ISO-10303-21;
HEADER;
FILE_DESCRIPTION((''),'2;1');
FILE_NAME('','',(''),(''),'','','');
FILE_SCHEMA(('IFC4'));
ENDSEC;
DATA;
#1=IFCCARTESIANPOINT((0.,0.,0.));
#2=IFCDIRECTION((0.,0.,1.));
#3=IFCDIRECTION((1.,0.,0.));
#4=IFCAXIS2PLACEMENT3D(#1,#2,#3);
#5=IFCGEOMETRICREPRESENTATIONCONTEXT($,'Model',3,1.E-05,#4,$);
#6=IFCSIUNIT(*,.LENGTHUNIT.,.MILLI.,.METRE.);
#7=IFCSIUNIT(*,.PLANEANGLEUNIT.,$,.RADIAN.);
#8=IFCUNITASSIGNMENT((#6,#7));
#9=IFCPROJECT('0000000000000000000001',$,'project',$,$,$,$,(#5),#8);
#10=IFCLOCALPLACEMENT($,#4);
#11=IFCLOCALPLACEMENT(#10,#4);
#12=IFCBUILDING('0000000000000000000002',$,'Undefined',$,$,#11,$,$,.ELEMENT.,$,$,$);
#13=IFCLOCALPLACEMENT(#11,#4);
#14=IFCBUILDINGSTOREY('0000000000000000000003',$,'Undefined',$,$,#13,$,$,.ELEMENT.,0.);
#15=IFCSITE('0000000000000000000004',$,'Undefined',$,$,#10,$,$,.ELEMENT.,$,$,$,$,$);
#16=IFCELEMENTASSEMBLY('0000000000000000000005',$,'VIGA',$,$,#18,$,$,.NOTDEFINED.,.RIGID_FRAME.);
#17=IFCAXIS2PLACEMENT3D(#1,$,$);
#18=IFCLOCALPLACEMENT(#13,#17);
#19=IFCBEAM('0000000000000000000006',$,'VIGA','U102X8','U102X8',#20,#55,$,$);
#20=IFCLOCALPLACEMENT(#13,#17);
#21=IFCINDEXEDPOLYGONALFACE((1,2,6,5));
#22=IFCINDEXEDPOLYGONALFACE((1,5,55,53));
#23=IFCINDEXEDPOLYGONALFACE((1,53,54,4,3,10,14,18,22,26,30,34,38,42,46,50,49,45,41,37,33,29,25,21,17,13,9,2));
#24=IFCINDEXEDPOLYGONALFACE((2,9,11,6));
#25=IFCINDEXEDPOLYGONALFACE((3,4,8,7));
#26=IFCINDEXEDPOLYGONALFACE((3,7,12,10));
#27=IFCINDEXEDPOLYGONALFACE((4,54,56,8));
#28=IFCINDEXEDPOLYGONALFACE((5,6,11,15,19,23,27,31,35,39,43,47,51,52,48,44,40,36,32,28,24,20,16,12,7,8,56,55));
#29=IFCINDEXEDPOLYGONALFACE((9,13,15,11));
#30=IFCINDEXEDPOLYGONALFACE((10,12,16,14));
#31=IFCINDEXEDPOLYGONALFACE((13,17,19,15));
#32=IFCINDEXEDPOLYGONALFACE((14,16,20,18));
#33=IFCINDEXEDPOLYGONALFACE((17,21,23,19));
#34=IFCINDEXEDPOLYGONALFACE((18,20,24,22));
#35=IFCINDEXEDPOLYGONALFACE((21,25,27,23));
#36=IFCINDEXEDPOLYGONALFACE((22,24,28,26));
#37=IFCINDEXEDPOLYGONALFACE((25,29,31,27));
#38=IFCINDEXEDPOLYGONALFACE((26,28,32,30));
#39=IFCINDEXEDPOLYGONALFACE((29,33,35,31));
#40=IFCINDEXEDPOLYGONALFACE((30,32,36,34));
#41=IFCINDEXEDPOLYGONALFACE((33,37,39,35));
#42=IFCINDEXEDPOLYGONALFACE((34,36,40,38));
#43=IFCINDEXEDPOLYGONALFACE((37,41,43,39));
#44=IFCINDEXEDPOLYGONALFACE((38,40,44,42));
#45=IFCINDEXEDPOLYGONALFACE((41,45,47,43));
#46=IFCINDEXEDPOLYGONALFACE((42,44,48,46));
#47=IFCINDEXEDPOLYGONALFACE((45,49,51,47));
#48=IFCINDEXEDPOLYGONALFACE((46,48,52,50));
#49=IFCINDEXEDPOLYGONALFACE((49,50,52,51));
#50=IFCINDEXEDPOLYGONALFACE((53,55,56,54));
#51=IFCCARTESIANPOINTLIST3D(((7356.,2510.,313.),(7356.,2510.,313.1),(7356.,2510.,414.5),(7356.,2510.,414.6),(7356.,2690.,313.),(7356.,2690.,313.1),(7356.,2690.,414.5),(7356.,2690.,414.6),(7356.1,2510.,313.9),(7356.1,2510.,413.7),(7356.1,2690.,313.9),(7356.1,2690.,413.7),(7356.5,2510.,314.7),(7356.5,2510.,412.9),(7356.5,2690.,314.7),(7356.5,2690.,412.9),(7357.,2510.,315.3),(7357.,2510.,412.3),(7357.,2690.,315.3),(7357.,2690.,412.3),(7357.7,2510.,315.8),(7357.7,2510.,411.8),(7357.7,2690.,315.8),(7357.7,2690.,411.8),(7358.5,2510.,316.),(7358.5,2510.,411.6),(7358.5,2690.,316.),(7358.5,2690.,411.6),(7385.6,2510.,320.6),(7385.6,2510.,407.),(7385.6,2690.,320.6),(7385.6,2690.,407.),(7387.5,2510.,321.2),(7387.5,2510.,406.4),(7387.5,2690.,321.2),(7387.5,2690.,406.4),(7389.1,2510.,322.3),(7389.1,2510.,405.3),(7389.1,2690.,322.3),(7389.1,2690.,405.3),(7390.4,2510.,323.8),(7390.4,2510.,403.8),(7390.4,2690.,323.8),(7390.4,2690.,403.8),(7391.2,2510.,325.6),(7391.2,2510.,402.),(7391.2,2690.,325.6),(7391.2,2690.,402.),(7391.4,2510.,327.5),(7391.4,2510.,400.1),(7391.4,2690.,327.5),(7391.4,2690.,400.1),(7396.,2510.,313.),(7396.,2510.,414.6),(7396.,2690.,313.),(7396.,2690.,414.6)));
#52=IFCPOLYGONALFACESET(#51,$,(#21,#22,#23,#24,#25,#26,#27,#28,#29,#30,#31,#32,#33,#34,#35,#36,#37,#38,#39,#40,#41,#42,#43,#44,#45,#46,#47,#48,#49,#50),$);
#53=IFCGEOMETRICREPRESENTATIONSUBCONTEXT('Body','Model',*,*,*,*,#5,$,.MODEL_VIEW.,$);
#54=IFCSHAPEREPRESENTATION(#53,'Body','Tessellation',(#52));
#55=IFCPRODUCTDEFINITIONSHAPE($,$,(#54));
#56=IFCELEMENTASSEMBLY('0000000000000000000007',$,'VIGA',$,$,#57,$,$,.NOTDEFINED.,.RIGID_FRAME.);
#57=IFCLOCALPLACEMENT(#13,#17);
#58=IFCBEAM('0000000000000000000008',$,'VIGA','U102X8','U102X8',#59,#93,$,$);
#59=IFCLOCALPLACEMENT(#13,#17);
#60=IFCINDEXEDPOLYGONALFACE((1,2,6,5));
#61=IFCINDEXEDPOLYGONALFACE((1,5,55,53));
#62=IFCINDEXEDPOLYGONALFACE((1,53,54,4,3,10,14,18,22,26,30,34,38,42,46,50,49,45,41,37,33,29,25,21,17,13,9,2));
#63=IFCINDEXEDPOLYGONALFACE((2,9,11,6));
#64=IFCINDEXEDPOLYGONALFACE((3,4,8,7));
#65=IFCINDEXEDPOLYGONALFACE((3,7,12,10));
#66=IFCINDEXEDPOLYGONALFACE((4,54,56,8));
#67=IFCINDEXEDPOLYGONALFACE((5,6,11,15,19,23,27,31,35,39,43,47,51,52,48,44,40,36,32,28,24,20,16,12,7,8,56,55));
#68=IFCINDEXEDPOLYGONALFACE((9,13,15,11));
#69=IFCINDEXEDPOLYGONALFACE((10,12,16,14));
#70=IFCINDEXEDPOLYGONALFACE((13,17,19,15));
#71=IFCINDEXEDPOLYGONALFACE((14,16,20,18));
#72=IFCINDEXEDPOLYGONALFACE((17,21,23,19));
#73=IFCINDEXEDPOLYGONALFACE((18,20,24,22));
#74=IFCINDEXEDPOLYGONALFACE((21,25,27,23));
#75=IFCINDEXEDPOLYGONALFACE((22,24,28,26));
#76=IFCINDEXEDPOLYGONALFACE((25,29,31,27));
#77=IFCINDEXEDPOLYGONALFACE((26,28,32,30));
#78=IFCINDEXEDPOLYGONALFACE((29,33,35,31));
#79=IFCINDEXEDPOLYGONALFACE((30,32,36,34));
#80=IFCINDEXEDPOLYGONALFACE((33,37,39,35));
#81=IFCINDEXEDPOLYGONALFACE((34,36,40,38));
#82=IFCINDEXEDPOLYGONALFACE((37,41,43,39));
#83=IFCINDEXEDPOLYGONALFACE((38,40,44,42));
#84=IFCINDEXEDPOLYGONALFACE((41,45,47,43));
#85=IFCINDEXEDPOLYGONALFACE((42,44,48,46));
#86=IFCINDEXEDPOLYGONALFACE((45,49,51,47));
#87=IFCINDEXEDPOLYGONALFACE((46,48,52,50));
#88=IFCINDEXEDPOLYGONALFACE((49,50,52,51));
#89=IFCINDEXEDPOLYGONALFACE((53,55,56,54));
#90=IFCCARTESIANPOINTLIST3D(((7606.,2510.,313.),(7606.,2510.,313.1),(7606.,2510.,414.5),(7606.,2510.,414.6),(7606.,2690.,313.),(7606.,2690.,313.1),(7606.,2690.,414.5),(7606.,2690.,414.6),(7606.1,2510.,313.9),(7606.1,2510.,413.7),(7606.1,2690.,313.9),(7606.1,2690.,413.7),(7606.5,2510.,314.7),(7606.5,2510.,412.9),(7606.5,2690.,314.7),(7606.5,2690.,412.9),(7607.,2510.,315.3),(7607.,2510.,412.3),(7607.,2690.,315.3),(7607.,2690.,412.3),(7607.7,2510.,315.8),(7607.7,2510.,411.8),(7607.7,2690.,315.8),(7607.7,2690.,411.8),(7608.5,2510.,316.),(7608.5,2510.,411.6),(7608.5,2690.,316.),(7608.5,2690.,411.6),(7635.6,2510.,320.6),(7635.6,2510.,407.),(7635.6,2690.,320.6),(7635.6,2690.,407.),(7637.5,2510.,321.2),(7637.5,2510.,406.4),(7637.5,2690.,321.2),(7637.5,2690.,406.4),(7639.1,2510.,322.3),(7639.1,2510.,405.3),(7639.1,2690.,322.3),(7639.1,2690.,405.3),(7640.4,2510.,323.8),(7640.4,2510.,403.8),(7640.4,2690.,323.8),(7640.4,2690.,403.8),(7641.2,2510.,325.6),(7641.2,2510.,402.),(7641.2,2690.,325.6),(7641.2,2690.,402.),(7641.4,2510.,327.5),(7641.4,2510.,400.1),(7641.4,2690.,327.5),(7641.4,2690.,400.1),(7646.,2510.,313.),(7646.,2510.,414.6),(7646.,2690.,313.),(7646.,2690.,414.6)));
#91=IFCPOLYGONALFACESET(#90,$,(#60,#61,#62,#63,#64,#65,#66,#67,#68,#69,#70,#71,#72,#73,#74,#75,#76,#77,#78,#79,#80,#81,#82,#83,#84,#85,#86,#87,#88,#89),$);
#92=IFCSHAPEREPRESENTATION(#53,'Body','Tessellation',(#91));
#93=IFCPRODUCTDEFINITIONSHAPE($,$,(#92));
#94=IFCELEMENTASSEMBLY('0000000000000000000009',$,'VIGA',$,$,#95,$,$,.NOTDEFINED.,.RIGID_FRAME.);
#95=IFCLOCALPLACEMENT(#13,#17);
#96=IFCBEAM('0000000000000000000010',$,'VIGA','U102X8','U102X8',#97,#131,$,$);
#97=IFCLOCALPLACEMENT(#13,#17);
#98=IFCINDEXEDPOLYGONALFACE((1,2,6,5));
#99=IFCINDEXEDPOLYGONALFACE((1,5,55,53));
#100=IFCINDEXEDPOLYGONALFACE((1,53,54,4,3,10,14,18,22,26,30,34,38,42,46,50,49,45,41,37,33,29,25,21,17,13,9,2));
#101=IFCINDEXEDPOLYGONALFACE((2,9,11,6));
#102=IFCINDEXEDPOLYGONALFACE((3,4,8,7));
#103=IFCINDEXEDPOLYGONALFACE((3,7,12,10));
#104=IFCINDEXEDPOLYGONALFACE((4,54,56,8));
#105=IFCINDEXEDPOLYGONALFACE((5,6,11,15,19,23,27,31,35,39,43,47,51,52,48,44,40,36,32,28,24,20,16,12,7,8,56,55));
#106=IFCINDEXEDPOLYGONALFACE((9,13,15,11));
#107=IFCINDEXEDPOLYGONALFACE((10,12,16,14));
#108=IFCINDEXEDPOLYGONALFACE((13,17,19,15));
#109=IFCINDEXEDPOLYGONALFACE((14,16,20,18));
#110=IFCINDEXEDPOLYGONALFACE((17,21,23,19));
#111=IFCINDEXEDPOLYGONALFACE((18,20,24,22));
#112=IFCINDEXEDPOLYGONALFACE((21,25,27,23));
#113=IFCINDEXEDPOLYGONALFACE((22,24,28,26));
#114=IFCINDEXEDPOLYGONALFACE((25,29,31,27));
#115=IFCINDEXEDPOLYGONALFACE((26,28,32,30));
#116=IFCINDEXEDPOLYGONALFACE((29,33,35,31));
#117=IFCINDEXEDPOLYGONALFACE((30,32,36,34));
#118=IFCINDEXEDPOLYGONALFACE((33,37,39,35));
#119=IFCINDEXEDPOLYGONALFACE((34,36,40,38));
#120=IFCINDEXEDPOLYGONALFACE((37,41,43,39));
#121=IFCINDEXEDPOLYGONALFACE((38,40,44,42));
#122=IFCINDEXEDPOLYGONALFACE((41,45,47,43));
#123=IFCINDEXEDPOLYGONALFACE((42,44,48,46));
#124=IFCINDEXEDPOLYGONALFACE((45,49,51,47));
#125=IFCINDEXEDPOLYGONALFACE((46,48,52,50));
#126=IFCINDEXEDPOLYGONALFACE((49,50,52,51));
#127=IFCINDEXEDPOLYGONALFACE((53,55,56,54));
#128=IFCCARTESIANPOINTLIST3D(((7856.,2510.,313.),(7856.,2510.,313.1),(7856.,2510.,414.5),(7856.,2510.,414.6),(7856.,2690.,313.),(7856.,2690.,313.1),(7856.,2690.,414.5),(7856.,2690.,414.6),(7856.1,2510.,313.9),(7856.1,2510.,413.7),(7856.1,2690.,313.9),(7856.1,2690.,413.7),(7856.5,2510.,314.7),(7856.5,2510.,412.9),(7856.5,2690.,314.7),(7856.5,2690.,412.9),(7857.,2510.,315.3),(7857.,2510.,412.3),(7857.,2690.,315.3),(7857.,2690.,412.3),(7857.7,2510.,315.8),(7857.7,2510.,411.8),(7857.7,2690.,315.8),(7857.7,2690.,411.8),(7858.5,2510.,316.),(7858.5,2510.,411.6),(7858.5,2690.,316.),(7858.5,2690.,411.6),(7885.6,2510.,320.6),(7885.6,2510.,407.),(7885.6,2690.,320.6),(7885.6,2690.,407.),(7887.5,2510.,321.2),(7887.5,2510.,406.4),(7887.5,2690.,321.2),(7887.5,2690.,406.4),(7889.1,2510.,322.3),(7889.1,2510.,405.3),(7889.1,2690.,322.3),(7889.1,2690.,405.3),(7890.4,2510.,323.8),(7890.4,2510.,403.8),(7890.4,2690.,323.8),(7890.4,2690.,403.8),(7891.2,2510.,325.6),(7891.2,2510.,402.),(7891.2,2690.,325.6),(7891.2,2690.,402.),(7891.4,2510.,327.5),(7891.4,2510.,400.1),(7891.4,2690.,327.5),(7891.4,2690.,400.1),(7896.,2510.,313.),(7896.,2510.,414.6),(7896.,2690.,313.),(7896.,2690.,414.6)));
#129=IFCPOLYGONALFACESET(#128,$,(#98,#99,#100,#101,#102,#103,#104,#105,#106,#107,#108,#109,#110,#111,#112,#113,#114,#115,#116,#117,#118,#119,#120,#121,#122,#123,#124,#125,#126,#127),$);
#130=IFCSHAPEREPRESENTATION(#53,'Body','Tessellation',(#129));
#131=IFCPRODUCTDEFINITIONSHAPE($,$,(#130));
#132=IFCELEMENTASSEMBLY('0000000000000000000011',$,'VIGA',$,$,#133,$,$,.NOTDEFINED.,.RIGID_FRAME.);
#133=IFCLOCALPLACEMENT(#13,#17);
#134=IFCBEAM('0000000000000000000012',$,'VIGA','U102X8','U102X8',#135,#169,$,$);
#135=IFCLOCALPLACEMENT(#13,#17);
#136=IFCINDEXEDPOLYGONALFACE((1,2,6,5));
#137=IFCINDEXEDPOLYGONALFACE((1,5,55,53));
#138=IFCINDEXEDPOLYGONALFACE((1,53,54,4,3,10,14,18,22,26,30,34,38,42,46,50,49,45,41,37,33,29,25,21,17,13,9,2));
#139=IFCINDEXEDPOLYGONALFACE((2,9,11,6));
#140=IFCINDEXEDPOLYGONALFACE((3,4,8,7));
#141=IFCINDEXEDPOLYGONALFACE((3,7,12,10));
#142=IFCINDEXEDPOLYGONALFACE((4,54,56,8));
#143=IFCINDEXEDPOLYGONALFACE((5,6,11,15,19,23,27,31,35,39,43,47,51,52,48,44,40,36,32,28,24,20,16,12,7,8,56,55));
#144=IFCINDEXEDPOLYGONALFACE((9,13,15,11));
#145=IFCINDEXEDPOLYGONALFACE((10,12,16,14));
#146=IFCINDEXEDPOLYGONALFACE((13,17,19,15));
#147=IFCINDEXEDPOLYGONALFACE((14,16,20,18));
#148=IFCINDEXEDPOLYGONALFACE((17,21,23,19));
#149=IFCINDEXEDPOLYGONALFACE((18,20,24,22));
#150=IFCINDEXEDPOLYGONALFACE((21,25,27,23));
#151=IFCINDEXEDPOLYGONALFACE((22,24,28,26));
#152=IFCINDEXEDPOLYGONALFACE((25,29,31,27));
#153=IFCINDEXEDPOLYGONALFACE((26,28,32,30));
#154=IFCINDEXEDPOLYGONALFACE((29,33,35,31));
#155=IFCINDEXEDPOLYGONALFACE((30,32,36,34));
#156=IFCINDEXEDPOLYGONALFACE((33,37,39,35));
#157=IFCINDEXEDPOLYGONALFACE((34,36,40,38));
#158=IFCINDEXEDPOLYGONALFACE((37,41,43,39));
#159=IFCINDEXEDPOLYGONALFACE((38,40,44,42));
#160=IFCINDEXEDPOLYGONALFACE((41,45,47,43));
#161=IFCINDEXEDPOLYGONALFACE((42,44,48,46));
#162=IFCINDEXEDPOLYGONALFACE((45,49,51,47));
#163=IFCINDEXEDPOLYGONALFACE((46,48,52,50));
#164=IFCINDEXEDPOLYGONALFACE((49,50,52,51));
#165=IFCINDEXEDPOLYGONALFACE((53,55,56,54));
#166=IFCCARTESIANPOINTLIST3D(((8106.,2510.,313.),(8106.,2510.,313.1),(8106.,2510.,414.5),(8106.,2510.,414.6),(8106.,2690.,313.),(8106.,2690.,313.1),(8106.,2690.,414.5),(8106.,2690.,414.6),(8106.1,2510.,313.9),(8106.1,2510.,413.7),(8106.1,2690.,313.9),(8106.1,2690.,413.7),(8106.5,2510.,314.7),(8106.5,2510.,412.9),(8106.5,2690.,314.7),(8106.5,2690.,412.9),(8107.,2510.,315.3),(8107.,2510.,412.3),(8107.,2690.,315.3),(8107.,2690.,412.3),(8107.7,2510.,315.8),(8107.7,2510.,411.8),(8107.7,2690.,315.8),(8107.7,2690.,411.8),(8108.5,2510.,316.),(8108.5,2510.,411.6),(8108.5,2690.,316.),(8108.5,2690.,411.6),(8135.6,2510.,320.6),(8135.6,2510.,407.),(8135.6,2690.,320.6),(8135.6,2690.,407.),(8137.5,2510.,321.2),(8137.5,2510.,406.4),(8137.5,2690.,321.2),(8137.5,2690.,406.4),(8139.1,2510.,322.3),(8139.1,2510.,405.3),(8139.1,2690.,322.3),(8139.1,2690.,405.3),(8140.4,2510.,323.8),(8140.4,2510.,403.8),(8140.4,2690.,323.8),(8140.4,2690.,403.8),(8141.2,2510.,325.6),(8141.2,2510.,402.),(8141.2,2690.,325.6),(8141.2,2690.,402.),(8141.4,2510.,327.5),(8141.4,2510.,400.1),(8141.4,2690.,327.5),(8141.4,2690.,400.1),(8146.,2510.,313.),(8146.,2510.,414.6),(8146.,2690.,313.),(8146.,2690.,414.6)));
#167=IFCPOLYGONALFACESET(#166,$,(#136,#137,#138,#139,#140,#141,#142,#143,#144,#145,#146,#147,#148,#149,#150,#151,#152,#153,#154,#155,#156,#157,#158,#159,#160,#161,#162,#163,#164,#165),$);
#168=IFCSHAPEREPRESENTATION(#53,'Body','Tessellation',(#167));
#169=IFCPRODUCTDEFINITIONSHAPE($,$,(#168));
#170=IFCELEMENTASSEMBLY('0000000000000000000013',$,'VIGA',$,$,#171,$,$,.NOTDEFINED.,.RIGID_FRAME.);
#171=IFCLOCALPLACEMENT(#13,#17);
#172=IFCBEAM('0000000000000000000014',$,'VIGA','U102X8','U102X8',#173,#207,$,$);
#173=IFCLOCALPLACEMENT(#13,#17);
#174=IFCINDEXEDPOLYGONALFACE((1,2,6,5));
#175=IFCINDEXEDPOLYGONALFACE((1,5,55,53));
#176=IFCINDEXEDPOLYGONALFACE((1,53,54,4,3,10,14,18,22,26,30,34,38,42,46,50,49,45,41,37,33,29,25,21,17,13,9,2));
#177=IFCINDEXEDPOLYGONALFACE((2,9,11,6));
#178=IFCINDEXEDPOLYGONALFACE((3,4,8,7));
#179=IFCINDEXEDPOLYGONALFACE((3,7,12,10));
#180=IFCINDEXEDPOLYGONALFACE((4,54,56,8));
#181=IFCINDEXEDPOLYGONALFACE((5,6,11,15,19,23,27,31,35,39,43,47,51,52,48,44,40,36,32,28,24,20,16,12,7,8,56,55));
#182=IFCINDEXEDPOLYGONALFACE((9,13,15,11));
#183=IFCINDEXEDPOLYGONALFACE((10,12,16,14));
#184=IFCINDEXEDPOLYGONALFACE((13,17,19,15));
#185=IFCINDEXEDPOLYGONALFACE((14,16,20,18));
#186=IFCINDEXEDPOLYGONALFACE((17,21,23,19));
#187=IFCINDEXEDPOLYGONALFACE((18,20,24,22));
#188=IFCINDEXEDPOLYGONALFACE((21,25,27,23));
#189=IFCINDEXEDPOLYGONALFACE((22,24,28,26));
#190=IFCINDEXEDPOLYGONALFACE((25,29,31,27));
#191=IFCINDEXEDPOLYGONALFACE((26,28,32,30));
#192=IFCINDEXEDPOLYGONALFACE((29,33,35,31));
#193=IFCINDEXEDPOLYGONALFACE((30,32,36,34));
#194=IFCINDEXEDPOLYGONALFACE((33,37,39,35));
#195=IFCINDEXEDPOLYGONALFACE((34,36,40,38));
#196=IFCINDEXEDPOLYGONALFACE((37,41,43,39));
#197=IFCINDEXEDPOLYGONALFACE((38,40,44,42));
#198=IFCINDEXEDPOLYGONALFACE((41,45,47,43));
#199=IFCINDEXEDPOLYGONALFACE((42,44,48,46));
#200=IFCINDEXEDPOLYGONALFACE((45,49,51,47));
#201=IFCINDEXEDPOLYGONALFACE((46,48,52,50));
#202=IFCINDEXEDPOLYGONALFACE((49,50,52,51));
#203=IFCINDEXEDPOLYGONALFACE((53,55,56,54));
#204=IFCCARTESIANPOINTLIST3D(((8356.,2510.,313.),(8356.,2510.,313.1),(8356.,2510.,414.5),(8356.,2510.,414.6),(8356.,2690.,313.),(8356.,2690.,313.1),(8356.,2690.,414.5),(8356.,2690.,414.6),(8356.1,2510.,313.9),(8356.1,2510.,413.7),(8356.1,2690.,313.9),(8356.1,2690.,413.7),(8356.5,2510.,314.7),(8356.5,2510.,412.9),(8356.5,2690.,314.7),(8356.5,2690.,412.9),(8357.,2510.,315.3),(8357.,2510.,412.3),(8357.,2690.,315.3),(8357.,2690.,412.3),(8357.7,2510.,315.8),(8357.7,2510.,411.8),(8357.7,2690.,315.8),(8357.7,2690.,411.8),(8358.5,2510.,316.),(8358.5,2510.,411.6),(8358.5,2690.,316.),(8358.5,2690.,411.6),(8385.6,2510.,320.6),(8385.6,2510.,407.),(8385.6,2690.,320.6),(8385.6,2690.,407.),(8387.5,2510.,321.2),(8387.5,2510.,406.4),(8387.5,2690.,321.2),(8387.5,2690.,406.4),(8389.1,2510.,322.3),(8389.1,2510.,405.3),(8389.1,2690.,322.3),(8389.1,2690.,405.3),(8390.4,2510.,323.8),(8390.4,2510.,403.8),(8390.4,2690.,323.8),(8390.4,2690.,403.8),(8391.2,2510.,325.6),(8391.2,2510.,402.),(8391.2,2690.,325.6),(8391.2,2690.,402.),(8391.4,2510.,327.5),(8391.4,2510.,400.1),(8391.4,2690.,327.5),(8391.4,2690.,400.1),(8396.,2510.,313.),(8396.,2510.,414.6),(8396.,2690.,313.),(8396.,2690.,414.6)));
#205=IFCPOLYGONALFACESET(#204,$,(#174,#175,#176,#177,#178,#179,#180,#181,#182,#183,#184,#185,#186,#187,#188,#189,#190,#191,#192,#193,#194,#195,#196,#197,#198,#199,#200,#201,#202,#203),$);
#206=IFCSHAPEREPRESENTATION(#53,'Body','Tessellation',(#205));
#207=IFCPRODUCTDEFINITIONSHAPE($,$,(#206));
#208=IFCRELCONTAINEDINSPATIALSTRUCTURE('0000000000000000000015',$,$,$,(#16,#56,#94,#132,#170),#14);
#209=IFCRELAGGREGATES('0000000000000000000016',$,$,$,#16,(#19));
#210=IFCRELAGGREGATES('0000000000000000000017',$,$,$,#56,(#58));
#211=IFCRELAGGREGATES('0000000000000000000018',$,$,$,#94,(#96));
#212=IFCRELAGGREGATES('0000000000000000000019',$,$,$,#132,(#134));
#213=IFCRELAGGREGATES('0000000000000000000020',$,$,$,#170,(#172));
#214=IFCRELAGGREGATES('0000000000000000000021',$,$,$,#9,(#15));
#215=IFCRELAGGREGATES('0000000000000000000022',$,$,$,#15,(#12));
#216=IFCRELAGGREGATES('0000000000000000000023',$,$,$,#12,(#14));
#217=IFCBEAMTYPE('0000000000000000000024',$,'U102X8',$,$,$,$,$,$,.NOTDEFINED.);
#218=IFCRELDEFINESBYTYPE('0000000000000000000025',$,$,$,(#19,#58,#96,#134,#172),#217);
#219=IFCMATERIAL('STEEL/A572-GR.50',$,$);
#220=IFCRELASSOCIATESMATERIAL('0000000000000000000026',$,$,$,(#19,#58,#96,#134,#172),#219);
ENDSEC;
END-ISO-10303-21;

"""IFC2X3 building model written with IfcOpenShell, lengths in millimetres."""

from ifc_helpers import new_model, si_unit, frame, origin_with_axes, origin_2d_with_axis, place, context, subcontext, project, spatial, u_section, extrude, material, type_object, element, aggregate, save


model = new_model("IFC2X3")

# Units and contexts
model_context = context("Model", 3, precision=1e-05, world=origin_with_axes())
body_context = subcontext(model_context, "Body", "Model", "MODEL_VIEW")
ifc_project = project(units=[si_unit("LENGTHUNIT", "METRE", prefix="MILLI"), si_unit("PLANEANGLEUNIT", "RADIAN")], contexts=[model_context])

# Site, building, storey
site_placement = place(None, origin_with_axes())
site = spatial("IfcSite", under=ifc_project, at=site_placement, Name="Undefined", CompositionType="ELEMENT")
building_placement = place(site_placement, origin_with_axes())
building = spatial("IfcBuilding", under=site, at=building_placement, Name="Undefined", CompositionType="ELEMENT")
storey_placement = place(building_placement, origin_with_axes())
storey = spatial("IfcBuildingStorey", under=building, at=storey_placement, Name="Undefined", CompositionType="ELEMENT", Elevation=0.0)

# Element assemblies, beams
ifc_material_1 = material(Name="STEEL/A572-GR.50")
beam_type = type_object("IfcBeamType", Name="U102X8", PredefinedType="NOTDEFINED")
assembly_1_placement = place(storey_placement, origin_with_axes())
assembly_1 = element("IfcElementAssembly", 1, at=assembly_1_placement, inside=storey, Name="VIGA", AssemblyPlace="NOTDEFINED", PredefinedType="RIGID_FRAME")
beam_1_placement = place(assembly_1_placement, frame((7376.0, 2690.0, 363.8), z_axis=(0.0, 0.0, 1.0), x_axis=(0.0, -1.0, 0.0)))
beam_1 = element("IfcBeam", 2, at=beam_1_placement, type_object=beam_type, material=ifc_material_1, Name="VIGA", Description="U102X8", ObjectType="U102X8", context=body_context, shape_type="SweptSolid", body=[
    extrude(u_section(Depth=101.6, FlangeWidth=40.0, WebThickness=4.6, FlangeThickness=6.0, FilletRadius=7.0, EdgeRadius=3.0, FlangeSlope=0.16839, at=origin_2d_with_axis()), frame((180.0, 0.0, 0.0), z_axis=(-1.0, 0.0, 0.0), x_axis=(0.0, -1.0, 0.0)), (0.0, 0.0, 1.0), 180.0),
])
aggregate(assembly_1, [beam_1])
assembly_2_placement = place(storey_placement, origin_with_axes())
assembly_2 = element("IfcElementAssembly", 3, at=assembly_2_placement, inside=storey, Name="VIGA", AssemblyPlace="NOTDEFINED", PredefinedType="RIGID_FRAME")
beam_2_placement = place(assembly_2_placement, frame((7626.0, 2690.0, 363.8), z_axis=(0.0, 0.0, 1.0), x_axis=(0.0, -1.0, 0.0)))
beam_2 = element("IfcBeam", 4, at=beam_2_placement, type_object=beam_type, material=ifc_material_1, Name="VIGA", Description="U102X8", ObjectType="U102X8", context=body_context, shape_type="SweptSolid", body=[
    extrude(u_section(Depth=101.6, FlangeWidth=40.0, WebThickness=4.6, FlangeThickness=6.0, FilletRadius=7.0, EdgeRadius=3.0, FlangeSlope=0.16839, at=origin_2d_with_axis()), frame((180.0, 0.0, 0.0), z_axis=(-1.0, 0.0, 0.0), x_axis=(0.0, -1.0, 0.0)), (0.0, 0.0, 1.0), 180.0),
])
aggregate(assembly_2, [beam_2])
assembly_3_placement = place(storey_placement, origin_with_axes())
assembly_3 = element("IfcElementAssembly", 5, at=assembly_3_placement, inside=storey, Name="VIGA", AssemblyPlace="NOTDEFINED", PredefinedType="RIGID_FRAME")
beam_3_placement = place(assembly_3_placement, frame((7876.0, 2690.0, 363.8), z_axis=(0.0, 0.0, 1.0), x_axis=(0.0, -1.0, 0.0)))
beam_3 = element("IfcBeam", 6, at=beam_3_placement, type_object=beam_type, material=ifc_material_1, Name="VIGA", Description="U102X8", ObjectType="U102X8", context=body_context, shape_type="SweptSolid", body=[
    extrude(u_section(Depth=101.6, FlangeWidth=40.0, WebThickness=4.6, FlangeThickness=6.0, FilletRadius=7.0, EdgeRadius=3.0, FlangeSlope=0.16839, at=origin_2d_with_axis()), frame((180.0, 0.0, 0.0), z_axis=(-1.0, 0.0, 0.0), x_axis=(0.0, -1.0, 0.0)), (0.0, 0.0, 1.0), 180.0),
])
aggregate(assembly_3, [beam_3])
assembly_4_placement = place(storey_placement, origin_with_axes())
assembly_4 = element("IfcElementAssembly", 7, at=assembly_4_placement, inside=storey, Name="VIGA", AssemblyPlace="NOTDEFINED", PredefinedType="RIGID_FRAME")
beam_4_placement = place(assembly_4_placement, frame((8126.0, 2690.0, 363.8), z_axis=(0.0, 0.0, 1.0), x_axis=(0.0, -1.0, 0.0)))
beam_4 = element("IfcBeam", 8, at=beam_4_placement, type_object=beam_type, material=ifc_material_1, Name="VIGA", Description="U102X8", ObjectType="U102X8", context=body_context, shape_type="SweptSolid", body=[
    extrude(u_section(Depth=101.6, FlangeWidth=40.0, WebThickness=4.6, FlangeThickness=6.0, FilletRadius=7.0, EdgeRadius=3.0, FlangeSlope=0.16839, at=origin_2d_with_axis()), frame((180.0, 0.0, 0.0), z_axis=(-1.0, 0.0, 0.0), x_axis=(0.0, -1.0, 0.0)), (0.0, 0.0, 1.0), 180.0),
])
aggregate(assembly_4, [beam_4])
assembly_5_placement = place(storey_placement, origin_with_axes())
assembly_5 = element("IfcElementAssembly", 9, at=assembly_5_placement, inside=storey, Name="VIGA", AssemblyPlace="NOTDEFINED", PredefinedType="RIGID_FRAME")
beam_5_placement = place(assembly_5_placement, frame((8376.0, 2690.0, 363.8), z_axis=(0.0, 0.0, 1.0), x_axis=(0.0, -1.0, 0.0)))
beam_5 = element("IfcBeam", 10, at=beam_5_placement, type_object=beam_type, material=ifc_material_1, Name="VIGA", Description="U102X8", ObjectType="U102X8", context=body_context, shape_type="SweptSolid", body=[
    extrude(u_section(Depth=101.6, FlangeWidth=40.0, WebThickness=4.6, FlangeThickness=6.0, FilletRadius=7.0, EdgeRadius=3.0, FlangeSlope=0.16839, at=origin_2d_with_axis()), frame((180.0, 0.0, 0.0), z_axis=(-1.0, 0.0, 0.0), x_axis=(0.0, -1.0, 0.0)), (0.0, 0.0, 1.0), 180.0),
])
aggregate(assembly_5, [beam_5])

save(model, "model.ifc")
